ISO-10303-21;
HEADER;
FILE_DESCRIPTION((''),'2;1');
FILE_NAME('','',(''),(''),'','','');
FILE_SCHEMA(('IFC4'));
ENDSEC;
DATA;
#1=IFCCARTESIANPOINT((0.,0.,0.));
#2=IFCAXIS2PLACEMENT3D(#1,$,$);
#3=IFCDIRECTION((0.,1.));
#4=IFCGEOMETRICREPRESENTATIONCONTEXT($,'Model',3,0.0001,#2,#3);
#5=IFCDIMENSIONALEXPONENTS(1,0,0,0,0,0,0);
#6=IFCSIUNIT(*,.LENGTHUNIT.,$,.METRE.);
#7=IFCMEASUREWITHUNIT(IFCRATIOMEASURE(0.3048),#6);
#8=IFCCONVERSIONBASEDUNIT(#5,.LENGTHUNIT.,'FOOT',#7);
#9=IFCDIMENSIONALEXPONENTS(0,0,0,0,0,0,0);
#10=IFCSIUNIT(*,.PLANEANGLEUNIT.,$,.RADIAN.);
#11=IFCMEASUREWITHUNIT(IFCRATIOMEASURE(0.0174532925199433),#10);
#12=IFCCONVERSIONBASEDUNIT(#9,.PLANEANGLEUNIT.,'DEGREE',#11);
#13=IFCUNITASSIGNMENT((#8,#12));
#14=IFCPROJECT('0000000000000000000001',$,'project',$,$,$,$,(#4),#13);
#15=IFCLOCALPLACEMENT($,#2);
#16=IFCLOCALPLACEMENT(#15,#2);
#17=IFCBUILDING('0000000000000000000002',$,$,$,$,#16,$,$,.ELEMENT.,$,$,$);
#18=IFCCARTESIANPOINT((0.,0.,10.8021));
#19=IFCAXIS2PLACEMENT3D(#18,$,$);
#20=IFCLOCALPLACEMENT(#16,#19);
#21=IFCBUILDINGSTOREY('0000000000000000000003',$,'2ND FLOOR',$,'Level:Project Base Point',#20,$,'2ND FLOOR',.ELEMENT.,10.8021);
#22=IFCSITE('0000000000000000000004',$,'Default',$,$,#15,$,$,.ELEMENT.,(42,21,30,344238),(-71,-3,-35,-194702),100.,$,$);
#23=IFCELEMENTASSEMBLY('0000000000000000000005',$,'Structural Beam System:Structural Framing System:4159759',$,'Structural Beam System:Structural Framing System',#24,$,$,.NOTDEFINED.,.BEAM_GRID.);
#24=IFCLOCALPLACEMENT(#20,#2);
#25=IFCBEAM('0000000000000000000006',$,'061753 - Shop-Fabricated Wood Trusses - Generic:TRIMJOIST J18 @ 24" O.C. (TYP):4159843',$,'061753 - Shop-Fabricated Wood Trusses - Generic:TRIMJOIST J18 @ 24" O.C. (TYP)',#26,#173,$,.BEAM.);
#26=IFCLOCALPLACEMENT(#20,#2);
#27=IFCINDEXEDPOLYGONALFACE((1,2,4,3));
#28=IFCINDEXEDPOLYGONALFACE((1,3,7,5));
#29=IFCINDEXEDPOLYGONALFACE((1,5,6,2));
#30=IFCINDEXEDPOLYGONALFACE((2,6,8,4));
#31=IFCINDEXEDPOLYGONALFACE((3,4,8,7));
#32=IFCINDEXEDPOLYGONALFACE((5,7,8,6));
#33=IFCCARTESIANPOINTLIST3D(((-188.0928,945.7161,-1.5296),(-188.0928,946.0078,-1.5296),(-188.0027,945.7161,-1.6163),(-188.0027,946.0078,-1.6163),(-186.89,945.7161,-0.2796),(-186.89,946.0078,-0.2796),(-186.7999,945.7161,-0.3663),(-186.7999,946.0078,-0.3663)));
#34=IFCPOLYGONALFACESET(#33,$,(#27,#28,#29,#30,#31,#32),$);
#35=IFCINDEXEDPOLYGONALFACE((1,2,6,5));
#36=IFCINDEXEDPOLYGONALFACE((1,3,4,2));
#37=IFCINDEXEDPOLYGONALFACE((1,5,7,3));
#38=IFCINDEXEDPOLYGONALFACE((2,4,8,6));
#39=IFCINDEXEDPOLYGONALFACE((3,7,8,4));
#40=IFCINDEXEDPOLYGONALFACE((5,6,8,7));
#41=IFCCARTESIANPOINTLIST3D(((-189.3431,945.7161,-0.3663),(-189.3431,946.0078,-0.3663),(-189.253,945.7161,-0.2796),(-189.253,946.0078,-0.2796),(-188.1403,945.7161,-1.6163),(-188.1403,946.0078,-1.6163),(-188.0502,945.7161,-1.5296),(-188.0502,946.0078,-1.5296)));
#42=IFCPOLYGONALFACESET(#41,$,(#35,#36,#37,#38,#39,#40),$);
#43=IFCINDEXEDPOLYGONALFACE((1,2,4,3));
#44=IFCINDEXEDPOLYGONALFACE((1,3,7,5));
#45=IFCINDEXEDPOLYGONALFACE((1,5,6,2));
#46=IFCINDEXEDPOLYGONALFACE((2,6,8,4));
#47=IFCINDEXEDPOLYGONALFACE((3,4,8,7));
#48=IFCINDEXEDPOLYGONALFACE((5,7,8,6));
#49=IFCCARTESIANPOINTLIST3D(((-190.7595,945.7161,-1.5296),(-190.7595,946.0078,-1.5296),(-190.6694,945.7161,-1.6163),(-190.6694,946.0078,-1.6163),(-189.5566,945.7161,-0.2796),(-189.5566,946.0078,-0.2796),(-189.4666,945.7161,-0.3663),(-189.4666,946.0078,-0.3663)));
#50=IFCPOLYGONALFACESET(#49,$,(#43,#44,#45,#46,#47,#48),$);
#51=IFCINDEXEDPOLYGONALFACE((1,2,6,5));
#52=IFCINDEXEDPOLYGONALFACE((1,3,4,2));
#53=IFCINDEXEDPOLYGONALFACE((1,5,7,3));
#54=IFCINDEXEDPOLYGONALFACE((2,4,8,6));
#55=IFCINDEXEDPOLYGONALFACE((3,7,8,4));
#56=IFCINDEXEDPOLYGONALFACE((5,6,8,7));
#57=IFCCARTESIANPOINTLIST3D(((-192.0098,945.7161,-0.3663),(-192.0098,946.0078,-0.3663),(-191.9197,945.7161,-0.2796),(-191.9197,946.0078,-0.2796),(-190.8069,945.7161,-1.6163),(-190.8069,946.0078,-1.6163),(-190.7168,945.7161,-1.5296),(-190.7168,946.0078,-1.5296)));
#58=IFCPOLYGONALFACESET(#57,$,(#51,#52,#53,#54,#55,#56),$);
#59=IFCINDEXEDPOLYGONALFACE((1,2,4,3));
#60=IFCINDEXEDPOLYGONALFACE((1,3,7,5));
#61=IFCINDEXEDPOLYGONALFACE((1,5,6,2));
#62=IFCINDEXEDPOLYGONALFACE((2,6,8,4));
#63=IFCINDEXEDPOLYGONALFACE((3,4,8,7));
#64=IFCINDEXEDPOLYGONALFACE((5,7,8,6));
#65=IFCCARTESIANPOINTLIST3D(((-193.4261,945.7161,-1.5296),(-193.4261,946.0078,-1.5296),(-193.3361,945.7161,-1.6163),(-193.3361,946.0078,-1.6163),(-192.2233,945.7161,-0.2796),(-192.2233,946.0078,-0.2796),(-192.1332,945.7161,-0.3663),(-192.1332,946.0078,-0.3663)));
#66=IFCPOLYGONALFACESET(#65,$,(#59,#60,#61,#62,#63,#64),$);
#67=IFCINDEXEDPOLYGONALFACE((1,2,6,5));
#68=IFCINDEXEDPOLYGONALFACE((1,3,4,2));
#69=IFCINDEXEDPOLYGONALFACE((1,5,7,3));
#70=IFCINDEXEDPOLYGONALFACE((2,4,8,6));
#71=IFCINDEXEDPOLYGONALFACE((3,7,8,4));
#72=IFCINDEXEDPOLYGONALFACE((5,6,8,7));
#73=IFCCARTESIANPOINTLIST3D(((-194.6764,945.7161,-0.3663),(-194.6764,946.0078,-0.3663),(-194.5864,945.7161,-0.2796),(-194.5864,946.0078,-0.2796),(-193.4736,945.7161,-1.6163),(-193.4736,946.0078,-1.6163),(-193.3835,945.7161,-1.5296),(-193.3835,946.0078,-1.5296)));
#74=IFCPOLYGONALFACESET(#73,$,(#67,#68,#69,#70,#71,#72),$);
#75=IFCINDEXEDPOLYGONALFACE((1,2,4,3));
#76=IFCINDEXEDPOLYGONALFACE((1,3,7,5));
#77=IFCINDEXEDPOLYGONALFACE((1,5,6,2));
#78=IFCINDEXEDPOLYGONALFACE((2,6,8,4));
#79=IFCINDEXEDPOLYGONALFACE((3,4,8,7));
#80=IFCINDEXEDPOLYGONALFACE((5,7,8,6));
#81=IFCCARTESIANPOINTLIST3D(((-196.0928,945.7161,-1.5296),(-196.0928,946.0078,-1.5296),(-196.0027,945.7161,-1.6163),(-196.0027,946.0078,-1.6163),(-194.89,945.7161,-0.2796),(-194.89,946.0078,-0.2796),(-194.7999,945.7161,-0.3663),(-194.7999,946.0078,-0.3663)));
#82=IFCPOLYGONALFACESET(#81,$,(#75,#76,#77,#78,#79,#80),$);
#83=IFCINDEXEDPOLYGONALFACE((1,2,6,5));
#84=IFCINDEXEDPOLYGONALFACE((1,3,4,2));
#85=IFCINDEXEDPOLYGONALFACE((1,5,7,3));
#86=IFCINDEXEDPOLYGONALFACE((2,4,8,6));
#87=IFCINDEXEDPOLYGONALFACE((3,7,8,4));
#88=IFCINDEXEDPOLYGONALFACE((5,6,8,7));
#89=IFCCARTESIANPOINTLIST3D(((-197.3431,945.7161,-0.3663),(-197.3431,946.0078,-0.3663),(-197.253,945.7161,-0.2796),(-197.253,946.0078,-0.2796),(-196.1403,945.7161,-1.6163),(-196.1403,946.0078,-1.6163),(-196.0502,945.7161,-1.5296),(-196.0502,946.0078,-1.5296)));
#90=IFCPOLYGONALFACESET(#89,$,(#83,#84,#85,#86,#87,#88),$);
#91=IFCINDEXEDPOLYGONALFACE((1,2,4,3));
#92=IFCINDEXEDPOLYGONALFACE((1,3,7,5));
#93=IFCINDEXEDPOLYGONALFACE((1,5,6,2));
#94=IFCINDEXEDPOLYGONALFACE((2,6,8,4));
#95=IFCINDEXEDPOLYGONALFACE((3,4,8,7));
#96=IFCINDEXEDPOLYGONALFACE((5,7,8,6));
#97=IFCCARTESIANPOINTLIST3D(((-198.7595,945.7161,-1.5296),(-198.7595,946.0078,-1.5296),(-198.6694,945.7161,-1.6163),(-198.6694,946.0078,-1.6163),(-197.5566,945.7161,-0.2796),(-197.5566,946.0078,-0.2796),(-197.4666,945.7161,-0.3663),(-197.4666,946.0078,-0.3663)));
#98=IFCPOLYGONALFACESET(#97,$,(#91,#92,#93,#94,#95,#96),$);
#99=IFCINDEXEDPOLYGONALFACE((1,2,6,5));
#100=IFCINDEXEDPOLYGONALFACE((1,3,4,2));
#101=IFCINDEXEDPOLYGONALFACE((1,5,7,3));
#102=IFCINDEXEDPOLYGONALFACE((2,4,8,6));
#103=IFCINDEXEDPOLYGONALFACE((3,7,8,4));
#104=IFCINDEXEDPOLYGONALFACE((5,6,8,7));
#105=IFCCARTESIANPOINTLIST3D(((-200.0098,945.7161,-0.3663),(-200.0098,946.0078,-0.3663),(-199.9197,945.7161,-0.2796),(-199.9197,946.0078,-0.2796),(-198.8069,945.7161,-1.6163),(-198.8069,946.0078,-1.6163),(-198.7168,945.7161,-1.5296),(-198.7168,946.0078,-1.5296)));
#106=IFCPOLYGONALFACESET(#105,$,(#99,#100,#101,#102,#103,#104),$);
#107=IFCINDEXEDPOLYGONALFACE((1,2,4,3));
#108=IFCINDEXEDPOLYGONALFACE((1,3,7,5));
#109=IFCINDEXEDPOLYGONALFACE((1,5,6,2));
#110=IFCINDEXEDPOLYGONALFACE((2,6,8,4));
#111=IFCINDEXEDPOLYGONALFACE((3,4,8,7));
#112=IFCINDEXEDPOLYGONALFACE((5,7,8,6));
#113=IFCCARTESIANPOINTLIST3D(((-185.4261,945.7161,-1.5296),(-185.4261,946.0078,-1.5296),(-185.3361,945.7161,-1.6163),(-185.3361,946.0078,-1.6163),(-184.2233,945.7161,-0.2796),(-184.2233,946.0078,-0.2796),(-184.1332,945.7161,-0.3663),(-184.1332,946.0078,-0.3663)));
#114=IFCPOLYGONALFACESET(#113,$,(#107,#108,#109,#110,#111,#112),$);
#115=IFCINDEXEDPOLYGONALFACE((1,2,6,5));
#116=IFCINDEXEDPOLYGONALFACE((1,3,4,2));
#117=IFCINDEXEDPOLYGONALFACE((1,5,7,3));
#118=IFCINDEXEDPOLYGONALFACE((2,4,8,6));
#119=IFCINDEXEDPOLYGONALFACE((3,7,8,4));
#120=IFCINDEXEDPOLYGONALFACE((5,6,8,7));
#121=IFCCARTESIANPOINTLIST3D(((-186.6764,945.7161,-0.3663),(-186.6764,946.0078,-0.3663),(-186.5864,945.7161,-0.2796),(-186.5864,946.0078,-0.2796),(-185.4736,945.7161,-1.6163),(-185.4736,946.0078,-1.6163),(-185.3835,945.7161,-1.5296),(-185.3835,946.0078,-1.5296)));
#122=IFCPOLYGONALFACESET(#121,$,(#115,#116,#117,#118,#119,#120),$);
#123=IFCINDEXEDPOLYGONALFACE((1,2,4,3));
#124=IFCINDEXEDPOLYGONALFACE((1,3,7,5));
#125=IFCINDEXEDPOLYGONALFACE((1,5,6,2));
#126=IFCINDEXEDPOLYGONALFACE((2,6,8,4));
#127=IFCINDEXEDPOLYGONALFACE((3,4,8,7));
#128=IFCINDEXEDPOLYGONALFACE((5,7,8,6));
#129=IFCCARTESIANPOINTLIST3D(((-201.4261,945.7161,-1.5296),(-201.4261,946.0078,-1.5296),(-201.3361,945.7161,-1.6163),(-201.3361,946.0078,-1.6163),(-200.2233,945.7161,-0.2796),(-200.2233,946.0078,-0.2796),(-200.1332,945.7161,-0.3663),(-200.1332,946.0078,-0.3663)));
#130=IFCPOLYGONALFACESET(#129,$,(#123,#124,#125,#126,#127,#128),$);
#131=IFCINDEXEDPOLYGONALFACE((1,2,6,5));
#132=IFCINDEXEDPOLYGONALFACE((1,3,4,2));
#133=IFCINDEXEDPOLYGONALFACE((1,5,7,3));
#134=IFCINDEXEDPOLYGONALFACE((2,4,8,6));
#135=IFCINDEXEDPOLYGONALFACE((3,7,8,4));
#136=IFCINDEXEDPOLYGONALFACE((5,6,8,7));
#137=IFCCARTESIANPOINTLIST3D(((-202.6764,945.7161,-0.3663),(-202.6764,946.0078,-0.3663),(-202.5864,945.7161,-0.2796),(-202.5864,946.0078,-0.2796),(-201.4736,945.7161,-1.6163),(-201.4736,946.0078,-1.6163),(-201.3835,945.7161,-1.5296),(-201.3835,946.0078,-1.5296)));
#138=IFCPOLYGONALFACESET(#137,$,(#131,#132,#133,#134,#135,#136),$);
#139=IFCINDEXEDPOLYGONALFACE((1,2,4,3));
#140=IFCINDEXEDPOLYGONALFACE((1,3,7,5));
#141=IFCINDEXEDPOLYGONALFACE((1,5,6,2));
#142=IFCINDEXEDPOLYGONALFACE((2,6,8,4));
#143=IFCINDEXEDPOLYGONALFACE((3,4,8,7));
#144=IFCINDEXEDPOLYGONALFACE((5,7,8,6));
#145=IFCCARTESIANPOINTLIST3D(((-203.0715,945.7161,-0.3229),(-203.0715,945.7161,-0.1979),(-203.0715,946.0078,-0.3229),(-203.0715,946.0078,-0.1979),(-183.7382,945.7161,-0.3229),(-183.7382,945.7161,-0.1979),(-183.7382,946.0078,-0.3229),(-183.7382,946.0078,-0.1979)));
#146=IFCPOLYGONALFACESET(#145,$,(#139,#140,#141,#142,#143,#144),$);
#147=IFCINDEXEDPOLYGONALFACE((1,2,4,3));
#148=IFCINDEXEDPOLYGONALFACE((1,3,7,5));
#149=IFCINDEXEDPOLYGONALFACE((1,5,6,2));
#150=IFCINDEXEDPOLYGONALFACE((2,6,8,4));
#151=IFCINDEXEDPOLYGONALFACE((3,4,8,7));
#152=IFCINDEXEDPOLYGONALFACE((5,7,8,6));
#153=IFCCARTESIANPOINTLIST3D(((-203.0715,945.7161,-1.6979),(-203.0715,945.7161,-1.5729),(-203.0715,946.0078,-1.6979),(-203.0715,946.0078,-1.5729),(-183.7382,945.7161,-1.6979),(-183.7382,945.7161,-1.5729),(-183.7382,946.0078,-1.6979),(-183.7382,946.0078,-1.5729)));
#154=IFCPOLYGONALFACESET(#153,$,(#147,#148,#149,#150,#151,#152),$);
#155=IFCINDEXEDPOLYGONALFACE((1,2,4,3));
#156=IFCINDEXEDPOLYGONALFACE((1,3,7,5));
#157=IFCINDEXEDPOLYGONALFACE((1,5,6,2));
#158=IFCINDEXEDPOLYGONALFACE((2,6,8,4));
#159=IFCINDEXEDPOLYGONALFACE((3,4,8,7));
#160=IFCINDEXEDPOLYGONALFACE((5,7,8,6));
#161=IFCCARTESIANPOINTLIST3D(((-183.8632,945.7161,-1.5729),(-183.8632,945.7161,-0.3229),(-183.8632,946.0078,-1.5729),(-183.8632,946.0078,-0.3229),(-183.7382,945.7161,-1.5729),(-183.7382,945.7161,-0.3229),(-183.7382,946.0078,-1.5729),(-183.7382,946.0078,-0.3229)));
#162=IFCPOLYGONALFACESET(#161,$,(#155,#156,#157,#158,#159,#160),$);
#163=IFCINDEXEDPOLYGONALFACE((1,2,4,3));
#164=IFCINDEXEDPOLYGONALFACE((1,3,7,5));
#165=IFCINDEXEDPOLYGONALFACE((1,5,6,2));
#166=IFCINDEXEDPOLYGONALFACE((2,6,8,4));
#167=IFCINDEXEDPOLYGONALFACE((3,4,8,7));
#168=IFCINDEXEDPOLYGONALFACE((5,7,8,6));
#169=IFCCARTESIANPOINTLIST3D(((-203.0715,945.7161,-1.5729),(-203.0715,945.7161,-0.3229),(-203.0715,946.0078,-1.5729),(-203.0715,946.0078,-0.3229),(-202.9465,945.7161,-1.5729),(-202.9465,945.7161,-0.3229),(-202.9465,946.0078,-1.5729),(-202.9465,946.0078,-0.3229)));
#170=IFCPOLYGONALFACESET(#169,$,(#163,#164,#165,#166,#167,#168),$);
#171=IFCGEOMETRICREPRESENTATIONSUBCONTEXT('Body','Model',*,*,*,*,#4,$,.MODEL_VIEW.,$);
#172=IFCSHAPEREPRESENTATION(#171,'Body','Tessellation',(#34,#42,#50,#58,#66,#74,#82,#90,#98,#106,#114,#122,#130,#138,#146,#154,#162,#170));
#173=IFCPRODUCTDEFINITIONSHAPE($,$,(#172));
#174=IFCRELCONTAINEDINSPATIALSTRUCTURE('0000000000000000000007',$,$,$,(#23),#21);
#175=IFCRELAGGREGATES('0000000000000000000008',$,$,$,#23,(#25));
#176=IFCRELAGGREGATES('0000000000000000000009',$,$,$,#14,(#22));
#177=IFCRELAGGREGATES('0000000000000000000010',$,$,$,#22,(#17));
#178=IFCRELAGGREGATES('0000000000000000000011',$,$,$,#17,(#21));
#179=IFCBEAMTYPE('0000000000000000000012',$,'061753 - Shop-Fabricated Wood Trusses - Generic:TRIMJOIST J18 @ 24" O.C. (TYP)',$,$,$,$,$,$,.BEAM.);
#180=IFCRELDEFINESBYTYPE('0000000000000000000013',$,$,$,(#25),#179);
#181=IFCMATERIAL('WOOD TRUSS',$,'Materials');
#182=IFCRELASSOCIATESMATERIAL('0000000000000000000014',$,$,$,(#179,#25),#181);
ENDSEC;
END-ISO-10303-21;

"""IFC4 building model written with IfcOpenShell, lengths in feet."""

from ifc_helpers import new_model, entity, si_unit, converted_unit, direction, frame, frame_2d, origin, origin_2d_with_axis, place, context, subcontext, project, spatial, rectangle, extrude, source, transform, mapped, material, material_profile, profile_set, profile_usage, type_object, type_shapes, element, aggregate, save


model = new_model("IFC4")

# Units and contexts
model_context = context("Model", 3, precision=0.0001, world=origin(), true_north=direction((0.0, 1.0)))
body_context = subcontext(model_context, "Body", "Model", "MODEL_VIEW")
ifc_project = project(units=[converted_unit("LENGTHUNIT", "FOOT", entity("IfcRatioMeasure", 0.3048), si_unit("LENGTHUNIT", "METRE"), dimensions=[1, 0, 0, 0, 0, 0, 0]), converted_unit("PLANEANGLEUNIT", "DEGREE", entity("IfcRatioMeasure", 0.0174532925199433), si_unit("PLANEANGLEUNIT", "RADIAN"), dimensions=[0, 0, 0, 0, 0, 0, 0])], contexts=[model_context])

# Site, building, storey
site_placement = place(None, origin())
site = spatial("IfcSite", under=ifc_project, at=site_placement, Name="Default", CompositionType="ELEMENT", RefLatitude=(42, 21, 30, 344238), RefLongitude=(-71, -3, -35, -194702), RefElevation=100.0)
building_placement = place(site_placement, origin())
building = spatial("IfcBuilding", under=site, at=building_placement, CompositionType="ELEMENT")
storey_placement = place(building_placement, frame((0.0, 0.0, 10.8021)))
storey = spatial("IfcBuildingStorey", under=building, at=storey_placement, Name="2ND FLOOR", ObjectType="Level:Project Base Point", LongName="2ND FLOOR", CompositionType="ELEMENT", Elevation=10.8021)

# Element assembly, beam
ifc_material_1 = material(Name="WOOD TRUSS", Category="Materials")
ifc_material_profile_1 = material_profile(ifc_material_1, rectangle(XDim=1.7347, YDim=0.125, at=frame_2d((0.0, 0.0), x_axis=(1.0, 0.0))), Name="TRIMJOIST J18 @ 24\" O.C. (TYP)")
ifc_material_profile_2 = material_profile(ifc_material_1, rectangle(XDim=1.7347, YDim=0.125, at=frame_2d((0.0, 0.0), x_axis=(1.0, 0.0))), Name="TRIMJOIST J18 @ 24\" O.C. (TYP)")
ifc_material_profile_3 = material_profile(ifc_material_1, rectangle(XDim=1.7347, YDim=0.125, at=frame_2d((0.0, 0.0), x_axis=(1.0, 0.0))), Name="TRIMJOIST J18 @ 24\" O.C. (TYP)")
ifc_material_profile_4 = material_profile(ifc_material_1, rectangle(XDim=1.7347, YDim=0.125, at=frame_2d((0.0, 0.0), x_axis=(1.0, 0.0))), Name="TRIMJOIST J18 @ 24\" O.C. (TYP)")
ifc_material_profile_5 = material_profile(ifc_material_1, rectangle(XDim=1.7347, YDim=0.125, at=frame_2d((0.0, 0.0), x_axis=(1.0, 0.0))), Name="TRIMJOIST J18 @ 24\" O.C. (TYP)")
ifc_material_profile_6 = material_profile(ifc_material_1, rectangle(XDim=1.7347, YDim=0.125, at=frame_2d((0.0, 0.0), x_axis=(1.0, 0.0))), Name="TRIMJOIST J18 @ 24\" O.C. (TYP)")
ifc_material_profile_7 = material_profile(ifc_material_1, rectangle(XDim=1.7347, YDim=0.125, at=frame_2d((0.0, 0.0), x_axis=(1.0, 0.0))), Name="TRIMJOIST J18 @ 24\" O.C. (TYP)")
ifc_material_profile_8 = material_profile(ifc_material_1, rectangle(XDim=1.7347, YDim=0.125, at=frame_2d((0.0, 0.0), x_axis=(1.0, 0.0))), Name="TRIMJOIST J18 @ 24\" O.C. (TYP)")
ifc_material_profile_9 = material_profile(ifc_material_1, rectangle(XDim=1.7347, YDim=0.125, at=frame_2d((0.0, 0.0), x_axis=(1.0, 0.0))), Name="TRIMJOIST J18 @ 24\" O.C. (TYP)")
ifc_material_profile_10 = material_profile(ifc_material_1, rectangle(XDim=1.7347, YDim=0.125, at=origin_2d_with_axis()), Name="TRIMJOIST J18 @ 24\" O.C. (TYP)")
ifc_material_profile_11 = material_profile(ifc_material_1, rectangle(XDim=0.125, YDim=0.2917, at=origin_2d_with_axis()), Name="TRIMJOIST J18 @ 24\" O.C. (TYP)")
ifc_material_profile_12 = material_profile(ifc_material_1, rectangle(XDim=0.125, YDim=0.2917, at=origin_2d_with_axis()), Name="TRIMJOIST J18 @ 24\" O.C. (TYP)")
ifc_material_profile_13 = material_profile(ifc_material_1, rectangle(XDim=1.25, YDim=0.2917, at=origin_2d_with_axis()), Name="TRIMJOIST J18 @ 24\" O.C. (TYP)")
ifc_material_profile_14 = material_profile(ifc_material_1, rectangle(XDim=1.25, YDim=0.2917, at=origin_2d_with_axis()), Name="TRIMJOIST J18 @ 24\" O.C. (TYP)")
ifc_profile_set_1 = profile_set([ifc_material_profile_1, ifc_material_profile_2, ifc_material_profile_3, ifc_material_profile_4, ifc_material_profile_5, ifc_material_profile_6, ifc_material_profile_7, ifc_material_profile_8, ifc_material_profile_9, ifc_material_profile_10, ifc_material_profile_11, ifc_material_profile_12, ifc_material_profile_13, ifc_material_profile_14], Name="TRIMJOIST J18 @ 24\" O.C. (TYP)")
beam_type_1 = type_object("IfcBeamType", Name="061753 - Shop-Fabricated Wood Trusses - Generic:TRIMJOIST J18 @ 24\" O.C. (TYP)", PredefinedType="BEAM", material=ifc_profile_set_1)
shared_shape_1 = source(origin(), body_context, "Body", "SweptSolid", [
    extrude(rectangle(XDim=1.7347, YDim=0.125, at=frame_2d((0.0, 0.0), x_axis=(1.0, 0.0))), frame((5.9585, -0.1458, 0.0), z_axis=(0.0, 1.0, 0.0), x_axis=(0.693383, 0.0, 0.720569)), (0.0, 0.0, 1.0), 0.2917),
    extrude(rectangle(XDim=1.7347, YDim=0.125, at=origin_2d_with_axis()), frame((4.7082, -0.1458, 0.0), z_axis=(0.0, 1.0, 0.0), x_axis=(0.693383, 0.0, -0.720569)), (0.0, 0.0, 1.0), 0.2917),
    extrude(rectangle(XDim=1.7347, YDim=0.125, at=frame_2d((0.0, 0.0), x_axis=(1.0, 0.0))), frame((3.2918, -0.1458, 0.0), z_axis=(0.0, 1.0, 0.0), x_axis=(0.693383, 0.0, 0.720569)), (0.0, 0.0, 1.0), 0.2917),
    extrude(rectangle(XDim=1.7347, YDim=0.125, at=frame_2d((0.0, 0.0), x_axis=(1.0, 0.0))), frame((2.0415, -0.1458, 0.0), z_axis=(0.0, 1.0, 0.0), x_axis=(0.693383, 0.0, -0.720569)), (0.0, 0.0, 1.0), 0.2917),
    extrude(rectangle(XDim=1.7347, YDim=0.125, at=frame_2d((0.0, 0.0), x_axis=(1.0, 0.0))), frame((0.6251, -0.1458, 0.0), z_axis=(0.0, 1.0, 0.0), x_axis=(0.693383, 0.0, 0.720569)), (0.0, 0.0, 1.0), 0.2917),
    extrude(rectangle(XDim=1.7347, YDim=0.125, at=frame_2d((0.0, 0.0), x_axis=(1.0, 0.0))), frame((-0.6251, -0.1458, 0.0), z_axis=(0.0, 1.0, 0.0), x_axis=(0.693383, 0.0, -0.720569)), (0.0, 0.0, 1.0), 0.2917),
    extrude(rectangle(XDim=1.7347, YDim=0.125, at=frame_2d((0.0, 0.0), x_axis=(1.0, 0.0))), frame((-2.0415, -0.1458, 0.0), z_axis=(0.0, 1.0, 0.0), x_axis=(0.693383, 0.0, 0.720569)), (0.0, 0.0, 1.0), 0.2917),
    extrude(rectangle(XDim=1.7347, YDim=0.125, at=origin_2d_with_axis()), frame((-3.2918, -0.1458, 0.0), z_axis=(0.0, 1.0, 0.0), x_axis=(0.693383, 0.0, -0.720569)), (0.0, 0.0, 1.0), 0.2917),
    extrude(rectangle(XDim=1.7347, YDim=0.125, at=frame_2d((0.0, 0.0), x_axis=(1.0, 0.0))), frame((-4.7082, -0.1458, 0.0), z_axis=(0.0, 1.0, 0.0), x_axis=(0.693383, 0.0, 0.720569)), (0.0, 0.0, 1.0), 0.2917),
    extrude(rectangle(XDim=1.7347, YDim=0.125, at=frame_2d((0.0, 0.0), x_axis=(1.0, 0.0))), frame((-5.9585, -0.1458, 0.0), z_axis=(0.0, 1.0, 0.0), x_axis=(0.693383, 0.0, -0.720569)), (0.0, 0.0, 1.0), 0.2917),
    extrude(rectangle(XDim=1.7347, YDim=0.125, at=frame_2d((0.0, 0.0), x_axis=(1.0, 0.0))), frame((8.6251, -0.1458, 0.0), z_axis=(0.0, 1.0, 0.0), x_axis=(0.693383, 0.0, 0.720569)), (0.0, 0.0, 1.0), 0.2917),
    extrude(rectangle(XDim=1.7347, YDim=0.125, at=origin_2d_with_axis()), frame((7.3749, -0.1458, 0.0), z_axis=(0.0, 1.0, 0.0), x_axis=(0.693383, 0.0, -0.720569)), (0.0, 0.0, 1.0), 0.2917),
    extrude(rectangle(XDim=1.7347, YDim=0.125, at=frame_2d((0.0, 0.0), x_axis=(1.0, 0.0))), frame((-7.3749, -0.1458, 0.0), z_axis=(0.0, 1.0, 0.0), x_axis=(0.693383, 0.0, 0.720569)), (0.0, 0.0, 1.0), 0.2917),
    extrude(rectangle(XDim=1.7347, YDim=0.125, at=origin_2d_with_axis()), frame((-8.6251, -0.1458, 0.0), z_axis=(0.0, 1.0, 0.0), x_axis=(0.693383, 0.0, -0.720569)), (0.0, 0.0, 1.0), 0.2917),
    extrude(rectangle(XDim=0.125, YDim=0.2917, at=origin_2d_with_axis()), frame((-9.6667, 0.0, 0.6875), z_axis=(1.0, 0.0, 0.0), x_axis=(0.0, 0.0, -1.0)), (0.0, 0.0, 1.0), 19.3333),
    extrude(rectangle(XDim=0.125, YDim=0.2917, at=origin_2d_with_axis()), frame((-9.6667, 0.0, -0.6875), z_axis=(1.0, 0.0, 0.0), x_axis=(0.0, 0.0, -1.0)), (0.0, 0.0, 1.0), 19.3333),
    extrude(rectangle(XDim=1.25, YDim=0.2917, at=origin_2d_with_axis()), frame((9.5417, 0.0, 0.0), z_axis=(1.0, 0.0, 0.0), x_axis=(0.0, 0.0, -1.0)), (0.0, 0.0, 1.0), 0.125),
    extrude(rectangle(XDim=1.25, YDim=0.2917, at=origin_2d_with_axis()), frame((-9.6667, 0.0, 0.0), z_axis=(1.0, 0.0, 0.0), x_axis=(0.0, 0.0, -1.0)), (0.0, 0.0, 1.0), 0.125),
])
type_shapes(beam_type_1, [shared_shape_1])
assembly_1_placement = place(storey_placement, origin())
assembly_1 = element("IfcElementAssembly", 1, at=assembly_1_placement, inside=storey, Name="Structural Beam System:Structural Framing System:4159759", ObjectType="Structural Beam System:Structural Framing System", AssemblyPlace="NOTDEFINED", PredefinedType="BEAM_GRID")
ifc_profile_usage_1 = profile_usage(ifc_profile_set_1, cardinal=8)
beam_1_placement = place(assembly_1_placement, frame((-193.4048, 945.8619, -0.9479)))
beam_1 = element("IfcBeam", 2, at=beam_1_placement, type_object=beam_type_1, material=ifc_profile_usage_1, Name="061753 - Shop-Fabricated Wood Trusses - Generic:TRIMJOIST J18 @ 24\" O.C. (TYP):4159843", ObjectType="061753 - Shop-Fabricated Wood Trusses - Generic:TRIMJOIST J18 @ 24\" O.C. (TYP)", PredefinedType="BEAM", context=body_context, shape_type="MappedRepresentation", body=[
    mapped(shared_shape_1, transform((0.0, 0.0, 0.0), scale=1.0)),
])

aggregate(assembly_1, [beam_1])

save(model, "model.ifc")
